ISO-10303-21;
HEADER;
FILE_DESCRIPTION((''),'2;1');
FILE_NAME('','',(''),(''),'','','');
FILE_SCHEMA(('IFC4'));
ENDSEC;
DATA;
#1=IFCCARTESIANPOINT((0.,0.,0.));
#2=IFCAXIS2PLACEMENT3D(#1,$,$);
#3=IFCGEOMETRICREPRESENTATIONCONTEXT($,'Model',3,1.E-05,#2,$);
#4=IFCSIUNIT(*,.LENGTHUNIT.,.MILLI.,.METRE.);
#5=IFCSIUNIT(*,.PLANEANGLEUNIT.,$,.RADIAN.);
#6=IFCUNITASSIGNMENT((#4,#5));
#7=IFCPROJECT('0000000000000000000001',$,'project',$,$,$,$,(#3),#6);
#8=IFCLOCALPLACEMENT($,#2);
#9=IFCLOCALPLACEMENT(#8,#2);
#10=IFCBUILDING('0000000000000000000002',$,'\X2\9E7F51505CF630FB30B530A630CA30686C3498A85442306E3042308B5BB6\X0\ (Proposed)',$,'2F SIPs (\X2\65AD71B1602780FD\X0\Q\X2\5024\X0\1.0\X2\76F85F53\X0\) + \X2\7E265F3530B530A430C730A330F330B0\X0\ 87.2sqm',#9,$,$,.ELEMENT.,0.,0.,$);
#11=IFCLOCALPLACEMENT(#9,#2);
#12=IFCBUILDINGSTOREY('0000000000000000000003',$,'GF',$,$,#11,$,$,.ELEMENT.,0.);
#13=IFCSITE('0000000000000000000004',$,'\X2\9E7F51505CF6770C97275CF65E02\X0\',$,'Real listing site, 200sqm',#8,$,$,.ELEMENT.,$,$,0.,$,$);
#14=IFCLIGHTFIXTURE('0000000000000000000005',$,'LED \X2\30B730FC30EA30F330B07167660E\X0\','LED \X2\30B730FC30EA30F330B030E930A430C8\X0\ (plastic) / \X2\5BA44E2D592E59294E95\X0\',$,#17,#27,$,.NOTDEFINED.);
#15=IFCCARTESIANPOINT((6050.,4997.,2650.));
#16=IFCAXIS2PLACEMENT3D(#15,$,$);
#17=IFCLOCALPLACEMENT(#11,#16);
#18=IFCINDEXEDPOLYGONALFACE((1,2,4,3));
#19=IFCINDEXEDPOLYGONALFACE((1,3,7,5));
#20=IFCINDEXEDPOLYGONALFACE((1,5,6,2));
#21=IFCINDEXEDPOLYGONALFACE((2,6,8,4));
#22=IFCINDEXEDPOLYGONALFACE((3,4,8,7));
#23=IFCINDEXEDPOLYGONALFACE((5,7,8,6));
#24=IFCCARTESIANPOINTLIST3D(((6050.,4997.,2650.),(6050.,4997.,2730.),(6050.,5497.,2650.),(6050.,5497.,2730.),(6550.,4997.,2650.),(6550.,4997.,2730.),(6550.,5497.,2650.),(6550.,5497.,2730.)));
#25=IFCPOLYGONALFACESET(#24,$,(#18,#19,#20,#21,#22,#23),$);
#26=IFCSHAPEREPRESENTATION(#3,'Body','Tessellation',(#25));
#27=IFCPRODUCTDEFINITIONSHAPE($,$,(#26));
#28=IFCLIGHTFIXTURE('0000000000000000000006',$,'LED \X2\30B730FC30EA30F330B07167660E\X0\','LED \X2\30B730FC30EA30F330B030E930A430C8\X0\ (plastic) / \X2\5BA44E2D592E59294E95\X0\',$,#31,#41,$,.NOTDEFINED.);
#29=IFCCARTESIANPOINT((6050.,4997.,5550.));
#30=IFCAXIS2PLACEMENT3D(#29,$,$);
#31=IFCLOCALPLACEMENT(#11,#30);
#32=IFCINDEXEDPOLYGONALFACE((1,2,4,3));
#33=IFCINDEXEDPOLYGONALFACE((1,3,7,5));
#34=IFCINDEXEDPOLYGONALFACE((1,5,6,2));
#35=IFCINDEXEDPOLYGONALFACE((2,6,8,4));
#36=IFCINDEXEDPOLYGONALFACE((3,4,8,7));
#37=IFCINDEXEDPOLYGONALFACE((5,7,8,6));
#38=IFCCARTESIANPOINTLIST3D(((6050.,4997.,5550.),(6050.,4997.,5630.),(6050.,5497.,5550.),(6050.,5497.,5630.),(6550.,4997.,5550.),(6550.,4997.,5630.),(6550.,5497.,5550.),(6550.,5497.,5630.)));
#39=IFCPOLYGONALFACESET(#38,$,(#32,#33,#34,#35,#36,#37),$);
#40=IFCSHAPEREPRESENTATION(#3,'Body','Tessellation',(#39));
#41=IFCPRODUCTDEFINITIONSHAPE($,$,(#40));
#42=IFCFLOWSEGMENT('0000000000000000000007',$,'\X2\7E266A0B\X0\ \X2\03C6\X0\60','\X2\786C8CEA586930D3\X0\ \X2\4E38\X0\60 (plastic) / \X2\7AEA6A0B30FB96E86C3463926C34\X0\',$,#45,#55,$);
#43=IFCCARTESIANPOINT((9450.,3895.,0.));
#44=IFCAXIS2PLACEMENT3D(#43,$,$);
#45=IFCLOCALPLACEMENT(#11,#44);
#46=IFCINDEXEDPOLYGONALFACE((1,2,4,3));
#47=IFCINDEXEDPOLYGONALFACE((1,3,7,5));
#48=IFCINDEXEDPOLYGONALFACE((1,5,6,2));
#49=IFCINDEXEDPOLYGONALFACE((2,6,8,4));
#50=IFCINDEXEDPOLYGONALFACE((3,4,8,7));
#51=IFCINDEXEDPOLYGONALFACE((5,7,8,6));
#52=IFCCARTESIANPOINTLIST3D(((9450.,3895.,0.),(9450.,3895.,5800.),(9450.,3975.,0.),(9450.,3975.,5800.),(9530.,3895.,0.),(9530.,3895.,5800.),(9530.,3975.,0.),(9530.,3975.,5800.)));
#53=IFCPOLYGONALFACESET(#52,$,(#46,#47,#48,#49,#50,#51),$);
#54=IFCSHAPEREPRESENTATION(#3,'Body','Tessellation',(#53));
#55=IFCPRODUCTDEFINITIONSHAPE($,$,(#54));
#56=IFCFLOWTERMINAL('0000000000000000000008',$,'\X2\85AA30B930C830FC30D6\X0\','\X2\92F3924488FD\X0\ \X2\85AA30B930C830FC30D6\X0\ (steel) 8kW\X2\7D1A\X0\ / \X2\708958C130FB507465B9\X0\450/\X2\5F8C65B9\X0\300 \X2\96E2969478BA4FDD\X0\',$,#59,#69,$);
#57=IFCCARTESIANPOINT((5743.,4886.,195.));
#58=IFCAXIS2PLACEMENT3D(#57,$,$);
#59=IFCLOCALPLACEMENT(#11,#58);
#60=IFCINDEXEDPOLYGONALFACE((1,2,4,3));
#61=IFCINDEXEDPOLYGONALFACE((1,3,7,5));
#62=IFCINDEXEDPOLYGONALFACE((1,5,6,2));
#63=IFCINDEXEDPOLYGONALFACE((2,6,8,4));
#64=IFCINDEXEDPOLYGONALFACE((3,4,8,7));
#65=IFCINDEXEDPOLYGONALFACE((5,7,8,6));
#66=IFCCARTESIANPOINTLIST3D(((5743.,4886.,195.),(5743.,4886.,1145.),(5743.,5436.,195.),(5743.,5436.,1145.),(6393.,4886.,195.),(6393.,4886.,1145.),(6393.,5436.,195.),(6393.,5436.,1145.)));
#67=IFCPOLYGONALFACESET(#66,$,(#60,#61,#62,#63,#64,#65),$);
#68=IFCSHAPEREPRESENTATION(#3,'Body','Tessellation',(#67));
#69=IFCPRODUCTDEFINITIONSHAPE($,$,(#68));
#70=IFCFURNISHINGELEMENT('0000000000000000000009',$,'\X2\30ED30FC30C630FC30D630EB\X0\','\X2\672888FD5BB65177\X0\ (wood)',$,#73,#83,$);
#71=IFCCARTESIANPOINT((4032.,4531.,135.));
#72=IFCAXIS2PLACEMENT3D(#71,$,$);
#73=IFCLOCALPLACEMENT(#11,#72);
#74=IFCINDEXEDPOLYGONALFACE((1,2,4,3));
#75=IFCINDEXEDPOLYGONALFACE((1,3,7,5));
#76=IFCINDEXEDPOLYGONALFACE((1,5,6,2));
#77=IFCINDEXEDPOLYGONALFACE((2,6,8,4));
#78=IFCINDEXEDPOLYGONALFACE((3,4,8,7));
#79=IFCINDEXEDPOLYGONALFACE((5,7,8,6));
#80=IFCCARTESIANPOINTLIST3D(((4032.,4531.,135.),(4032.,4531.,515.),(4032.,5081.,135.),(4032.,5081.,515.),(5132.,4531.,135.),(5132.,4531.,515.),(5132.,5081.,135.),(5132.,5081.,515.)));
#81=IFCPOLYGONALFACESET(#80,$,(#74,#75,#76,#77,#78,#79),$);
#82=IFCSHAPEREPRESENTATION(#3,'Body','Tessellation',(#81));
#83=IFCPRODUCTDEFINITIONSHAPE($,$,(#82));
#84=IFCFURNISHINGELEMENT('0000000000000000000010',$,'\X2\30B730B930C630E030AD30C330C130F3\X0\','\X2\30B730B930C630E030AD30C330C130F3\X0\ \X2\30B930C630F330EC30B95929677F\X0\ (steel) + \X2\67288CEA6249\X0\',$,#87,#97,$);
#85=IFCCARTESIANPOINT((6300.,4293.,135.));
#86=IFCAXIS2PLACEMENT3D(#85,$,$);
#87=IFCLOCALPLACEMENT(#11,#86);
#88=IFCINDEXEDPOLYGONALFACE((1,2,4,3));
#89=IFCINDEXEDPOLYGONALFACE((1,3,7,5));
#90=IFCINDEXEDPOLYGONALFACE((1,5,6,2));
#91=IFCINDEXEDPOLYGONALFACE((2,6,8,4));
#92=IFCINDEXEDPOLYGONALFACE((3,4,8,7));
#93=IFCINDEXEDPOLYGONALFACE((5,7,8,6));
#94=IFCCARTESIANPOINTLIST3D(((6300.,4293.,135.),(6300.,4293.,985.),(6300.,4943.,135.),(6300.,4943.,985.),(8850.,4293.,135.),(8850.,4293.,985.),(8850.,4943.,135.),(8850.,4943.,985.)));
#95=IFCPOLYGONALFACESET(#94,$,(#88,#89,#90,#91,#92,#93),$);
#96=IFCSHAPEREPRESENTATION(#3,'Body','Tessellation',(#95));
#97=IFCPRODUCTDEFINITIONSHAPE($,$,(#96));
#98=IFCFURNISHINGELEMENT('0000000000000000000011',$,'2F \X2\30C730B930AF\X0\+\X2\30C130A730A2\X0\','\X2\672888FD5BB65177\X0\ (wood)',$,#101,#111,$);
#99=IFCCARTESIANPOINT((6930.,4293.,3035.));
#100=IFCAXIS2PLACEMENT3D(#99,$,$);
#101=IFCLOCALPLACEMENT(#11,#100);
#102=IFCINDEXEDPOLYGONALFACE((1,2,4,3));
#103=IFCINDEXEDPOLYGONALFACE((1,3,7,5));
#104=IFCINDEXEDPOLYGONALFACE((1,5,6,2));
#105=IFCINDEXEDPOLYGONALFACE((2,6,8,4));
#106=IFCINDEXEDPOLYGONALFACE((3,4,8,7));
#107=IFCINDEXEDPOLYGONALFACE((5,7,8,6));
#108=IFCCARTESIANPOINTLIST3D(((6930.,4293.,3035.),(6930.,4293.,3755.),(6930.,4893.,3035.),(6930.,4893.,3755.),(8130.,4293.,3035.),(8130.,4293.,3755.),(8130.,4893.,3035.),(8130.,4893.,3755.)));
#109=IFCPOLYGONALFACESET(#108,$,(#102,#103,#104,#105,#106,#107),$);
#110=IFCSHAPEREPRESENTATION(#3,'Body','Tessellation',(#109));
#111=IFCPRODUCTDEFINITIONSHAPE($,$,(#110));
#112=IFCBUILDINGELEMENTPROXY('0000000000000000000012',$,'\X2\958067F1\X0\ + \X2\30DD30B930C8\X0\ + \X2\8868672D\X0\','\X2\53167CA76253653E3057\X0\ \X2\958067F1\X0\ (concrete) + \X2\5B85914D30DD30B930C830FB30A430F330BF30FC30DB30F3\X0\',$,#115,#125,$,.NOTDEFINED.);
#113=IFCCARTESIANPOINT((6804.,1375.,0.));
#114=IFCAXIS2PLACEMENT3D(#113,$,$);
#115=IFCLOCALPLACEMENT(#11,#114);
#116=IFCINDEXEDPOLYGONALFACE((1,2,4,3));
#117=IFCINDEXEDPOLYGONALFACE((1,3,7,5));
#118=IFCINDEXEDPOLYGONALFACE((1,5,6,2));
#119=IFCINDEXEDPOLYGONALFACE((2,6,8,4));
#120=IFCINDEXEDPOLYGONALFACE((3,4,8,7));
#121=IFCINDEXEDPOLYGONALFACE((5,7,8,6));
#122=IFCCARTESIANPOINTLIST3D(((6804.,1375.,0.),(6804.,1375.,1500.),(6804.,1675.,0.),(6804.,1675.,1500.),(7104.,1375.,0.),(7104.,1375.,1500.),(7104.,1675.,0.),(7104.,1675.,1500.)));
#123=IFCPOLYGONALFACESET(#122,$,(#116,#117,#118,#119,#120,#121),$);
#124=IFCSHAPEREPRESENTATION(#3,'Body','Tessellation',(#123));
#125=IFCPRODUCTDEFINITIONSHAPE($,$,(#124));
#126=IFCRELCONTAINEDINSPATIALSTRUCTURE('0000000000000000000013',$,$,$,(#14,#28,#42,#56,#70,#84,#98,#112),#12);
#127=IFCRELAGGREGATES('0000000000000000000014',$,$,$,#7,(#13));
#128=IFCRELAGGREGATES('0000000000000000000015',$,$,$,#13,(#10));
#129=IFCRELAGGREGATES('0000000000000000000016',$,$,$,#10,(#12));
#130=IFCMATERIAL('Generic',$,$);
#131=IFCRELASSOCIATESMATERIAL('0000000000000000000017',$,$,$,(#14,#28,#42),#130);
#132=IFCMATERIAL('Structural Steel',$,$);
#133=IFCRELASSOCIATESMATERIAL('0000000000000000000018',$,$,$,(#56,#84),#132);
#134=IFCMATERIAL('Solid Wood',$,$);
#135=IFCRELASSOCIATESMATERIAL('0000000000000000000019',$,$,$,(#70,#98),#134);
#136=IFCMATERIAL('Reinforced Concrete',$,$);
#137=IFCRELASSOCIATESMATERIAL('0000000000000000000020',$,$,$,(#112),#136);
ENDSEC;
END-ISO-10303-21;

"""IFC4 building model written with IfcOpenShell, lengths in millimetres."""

from ifc_helpers import new_model, si_unit, frame, frame_2d, origin, place, context, project, spatial, rectangle, extrude, material, element, save


model = new_model("IFC4")

# Units and contexts
model_context = context("Model", 3, precision=1e-05, world=origin())
ifc_project = project(units=[si_unit("LENGTHUNIT", "METRE", prefix="MILLI"), si_unit("PLANEANGLEUNIT", "RADIAN")], contexts=[model_context])

# Site, building, storey
site_placement = place(None, origin())
site = spatial("IfcSite", under=ifc_project, at=site_placement, Name="鹿児島県霧島市", ObjectType="Real listing site, 200sqm", CompositionType="ELEMENT", RefElevation=0.0)
building_placement = place(site_placement, origin())
building = spatial("IfcBuilding", under=site, at=building_placement, Name="鹿児島・サウナと水風呂のある家 (Proposed)", ObjectType="2F SIPs (断熱性能Q値1.0相当) + 縦張サイディング 87.2sqm", CompositionType="ELEMENT", ElevationOfRefHeight=0.0, ElevationOfTerrain=0.0)
storey_placement = place(building_placement, origin())
storey = spatial("IfcBuildingStorey", under=building, at=storey_placement, Name="GF", CompositionType="ELEMENT", Elevation=0.0)

# Shared definitions
ifc_material_1 = material(Name="Solid Wood")

# Shared definitions
ifc_material_2 = material(Name="Reinforced Concrete")

# Shared definitions
ifc_material_3 = material(Name="Structural Steel")

# Shared definitions
ifc_material_4 = material(Name="Generic")

# Light fixtures
light_fixture_1_placement = place(storey_placement, frame((6050.0, 4997.0, 2650.0)))
element("IfcLightFixture", 1, at=light_fixture_1_placement, inside=storey, material=ifc_material_4, Name="LED シーリング照明", Description="LED シーリングライト (plastic) / 室中央天井", PredefinedType="NOTDEFINED", context=model_context, shape_type="SweptSolid", body=[
    extrude(rectangle(XDim=500.0, YDim=500.0, at=frame_2d((250.0, 250.0))), frame((6050.0, 4997.0, 2650.0)), (0.0, 0.0, 1.0), 80.0),
])
light_fixture_2_placement = place(storey_placement, frame((6050.0, 4997.0, 5550.0)))
element("IfcLightFixture", 2, at=light_fixture_2_placement, inside=storey, material=ifc_material_4, Name="LED シーリング照明", Description="LED シーリングライト (plastic) / 室中央天井", PredefinedType="NOTDEFINED", context=model_context, shape_type="SweptSolid", body=[
    extrude(rectangle(XDim=500.0, YDim=500.0, at=frame_2d((250.0, 250.0))), frame((6050.0, 4997.0, 5550.0)), (0.0, 0.0, 1.0), 80.0),
])

# Flow segment
flow_segment_placement = place(storey_placement, frame((9450.0, 3895.0, 0.0)))
element("IfcFlowSegment", 3, at=flow_segment_placement, inside=storey, material=ifc_material_4, Name="縦樋 φ60", Description="硬質塩ビ 丸60 (plastic) / 竪樋・雨水排水", context=model_context, shape_type="SweptSolid", body=[
    extrude(rectangle(XDim=80.0, YDim=80.0, at=frame_2d((40.0, 40.0))), frame((9450.0, 3895.0, 0.0)), (0.0, 0.0, 1.0), 5800.0),
])

# Flow terminal
flow_terminal_1_placement = place(storey_placement, frame((5743.0, 4886.0, 195.0)))
element("IfcFlowTerminal", 4, at=flow_terminal_1_placement, inside=storey, material=ifc_material_3, Name="薪ストーブ", Description="鋳鉄製 薪ストーブ (steel) 8kW級 / 炉壁・側方450/後方300 離隔確保", context=model_context, shape_type="SweptSolid", body=[
    extrude(rectangle(XDim=650.0, YDim=550.0, at=frame_2d((325.0, 275.0))), frame((5743.0, 4886.0, 195.0)), (0.0, 0.0, 1.0), 950.0),
])

# Furnishing elements
furnishing_1_placement = place(storey_placement, frame((4032.0, 4531.0, 135.0)))
element("IfcFurnishingElement", 5, at=furnishing_1_placement, inside=storey, material=ifc_material_1, Name="ローテーブル", Description="木製家具 (wood)", context=model_context, shape_type="SweptSolid", body=[
    extrude(rectangle(XDim=1100.0, YDim=550.0, at=frame_2d((550.0, 275.0))), frame((4032.0, 4531.0, 135.0)), (0.0, 0.0, 1.0), 380.0),
])
furnishing_2_placement = place(storey_placement, frame((6300.0, 4293.0, 135.0)))
element("IfcFurnishingElement", 6, at=furnishing_2_placement, inside=storey, material=ifc_material_3, Name="システムキッチン", Description="システムキッチン ステンレス天板 (steel) + 木質扉", context=model_context, shape_type="SweptSolid", body=[
    extrude(rectangle(XDim=2550.0, YDim=650.0, at=frame_2d((1275.0, 325.0))), frame((6300.0, 4293.0, 135.0)), (0.0, 0.0, 1.0), 850.0),
])
furnishing_3_placement = place(storey_placement, frame((6930.0, 4293.0, 3035.0)))
element("IfcFurnishingElement", 7, at=furnishing_3_placement, inside=storey, material=ifc_material_1, Name="2F デスク+チェア", Description="木製家具 (wood)", context=model_context, shape_type="SweptSolid", body=[
    extrude(rectangle(XDim=1200.0, YDim=600.0, at=frame_2d((600.0, 300.0))), frame((6930.0, 4293.0, 3035.0)), (0.0, 0.0, 1.0), 720.0),
])

# Building element proxy
proxy_placement = place(storey_placement, frame((6804.0, 1375.0, 0.0)))
element("IfcBuildingElementProxy", 8, at=proxy_placement, inside=storey, material=ifc_material_2, Name="門柱 + ポスト + 表札", Description="化粧打放し 門柱 (concrete) + 宅配ポスト・インターホン", PredefinedType="NOTDEFINED", context=model_context, shape_type="SweptSolid", body=[
    extrude(rectangle(XDim=300.0, YDim=300.0, at=frame_2d((150.0, 150.0))), frame((6804.0, 1375.0, 0.0)), (0.0, 0.0, 1.0), 1500.0),
])

save(model, "model.ifc")
